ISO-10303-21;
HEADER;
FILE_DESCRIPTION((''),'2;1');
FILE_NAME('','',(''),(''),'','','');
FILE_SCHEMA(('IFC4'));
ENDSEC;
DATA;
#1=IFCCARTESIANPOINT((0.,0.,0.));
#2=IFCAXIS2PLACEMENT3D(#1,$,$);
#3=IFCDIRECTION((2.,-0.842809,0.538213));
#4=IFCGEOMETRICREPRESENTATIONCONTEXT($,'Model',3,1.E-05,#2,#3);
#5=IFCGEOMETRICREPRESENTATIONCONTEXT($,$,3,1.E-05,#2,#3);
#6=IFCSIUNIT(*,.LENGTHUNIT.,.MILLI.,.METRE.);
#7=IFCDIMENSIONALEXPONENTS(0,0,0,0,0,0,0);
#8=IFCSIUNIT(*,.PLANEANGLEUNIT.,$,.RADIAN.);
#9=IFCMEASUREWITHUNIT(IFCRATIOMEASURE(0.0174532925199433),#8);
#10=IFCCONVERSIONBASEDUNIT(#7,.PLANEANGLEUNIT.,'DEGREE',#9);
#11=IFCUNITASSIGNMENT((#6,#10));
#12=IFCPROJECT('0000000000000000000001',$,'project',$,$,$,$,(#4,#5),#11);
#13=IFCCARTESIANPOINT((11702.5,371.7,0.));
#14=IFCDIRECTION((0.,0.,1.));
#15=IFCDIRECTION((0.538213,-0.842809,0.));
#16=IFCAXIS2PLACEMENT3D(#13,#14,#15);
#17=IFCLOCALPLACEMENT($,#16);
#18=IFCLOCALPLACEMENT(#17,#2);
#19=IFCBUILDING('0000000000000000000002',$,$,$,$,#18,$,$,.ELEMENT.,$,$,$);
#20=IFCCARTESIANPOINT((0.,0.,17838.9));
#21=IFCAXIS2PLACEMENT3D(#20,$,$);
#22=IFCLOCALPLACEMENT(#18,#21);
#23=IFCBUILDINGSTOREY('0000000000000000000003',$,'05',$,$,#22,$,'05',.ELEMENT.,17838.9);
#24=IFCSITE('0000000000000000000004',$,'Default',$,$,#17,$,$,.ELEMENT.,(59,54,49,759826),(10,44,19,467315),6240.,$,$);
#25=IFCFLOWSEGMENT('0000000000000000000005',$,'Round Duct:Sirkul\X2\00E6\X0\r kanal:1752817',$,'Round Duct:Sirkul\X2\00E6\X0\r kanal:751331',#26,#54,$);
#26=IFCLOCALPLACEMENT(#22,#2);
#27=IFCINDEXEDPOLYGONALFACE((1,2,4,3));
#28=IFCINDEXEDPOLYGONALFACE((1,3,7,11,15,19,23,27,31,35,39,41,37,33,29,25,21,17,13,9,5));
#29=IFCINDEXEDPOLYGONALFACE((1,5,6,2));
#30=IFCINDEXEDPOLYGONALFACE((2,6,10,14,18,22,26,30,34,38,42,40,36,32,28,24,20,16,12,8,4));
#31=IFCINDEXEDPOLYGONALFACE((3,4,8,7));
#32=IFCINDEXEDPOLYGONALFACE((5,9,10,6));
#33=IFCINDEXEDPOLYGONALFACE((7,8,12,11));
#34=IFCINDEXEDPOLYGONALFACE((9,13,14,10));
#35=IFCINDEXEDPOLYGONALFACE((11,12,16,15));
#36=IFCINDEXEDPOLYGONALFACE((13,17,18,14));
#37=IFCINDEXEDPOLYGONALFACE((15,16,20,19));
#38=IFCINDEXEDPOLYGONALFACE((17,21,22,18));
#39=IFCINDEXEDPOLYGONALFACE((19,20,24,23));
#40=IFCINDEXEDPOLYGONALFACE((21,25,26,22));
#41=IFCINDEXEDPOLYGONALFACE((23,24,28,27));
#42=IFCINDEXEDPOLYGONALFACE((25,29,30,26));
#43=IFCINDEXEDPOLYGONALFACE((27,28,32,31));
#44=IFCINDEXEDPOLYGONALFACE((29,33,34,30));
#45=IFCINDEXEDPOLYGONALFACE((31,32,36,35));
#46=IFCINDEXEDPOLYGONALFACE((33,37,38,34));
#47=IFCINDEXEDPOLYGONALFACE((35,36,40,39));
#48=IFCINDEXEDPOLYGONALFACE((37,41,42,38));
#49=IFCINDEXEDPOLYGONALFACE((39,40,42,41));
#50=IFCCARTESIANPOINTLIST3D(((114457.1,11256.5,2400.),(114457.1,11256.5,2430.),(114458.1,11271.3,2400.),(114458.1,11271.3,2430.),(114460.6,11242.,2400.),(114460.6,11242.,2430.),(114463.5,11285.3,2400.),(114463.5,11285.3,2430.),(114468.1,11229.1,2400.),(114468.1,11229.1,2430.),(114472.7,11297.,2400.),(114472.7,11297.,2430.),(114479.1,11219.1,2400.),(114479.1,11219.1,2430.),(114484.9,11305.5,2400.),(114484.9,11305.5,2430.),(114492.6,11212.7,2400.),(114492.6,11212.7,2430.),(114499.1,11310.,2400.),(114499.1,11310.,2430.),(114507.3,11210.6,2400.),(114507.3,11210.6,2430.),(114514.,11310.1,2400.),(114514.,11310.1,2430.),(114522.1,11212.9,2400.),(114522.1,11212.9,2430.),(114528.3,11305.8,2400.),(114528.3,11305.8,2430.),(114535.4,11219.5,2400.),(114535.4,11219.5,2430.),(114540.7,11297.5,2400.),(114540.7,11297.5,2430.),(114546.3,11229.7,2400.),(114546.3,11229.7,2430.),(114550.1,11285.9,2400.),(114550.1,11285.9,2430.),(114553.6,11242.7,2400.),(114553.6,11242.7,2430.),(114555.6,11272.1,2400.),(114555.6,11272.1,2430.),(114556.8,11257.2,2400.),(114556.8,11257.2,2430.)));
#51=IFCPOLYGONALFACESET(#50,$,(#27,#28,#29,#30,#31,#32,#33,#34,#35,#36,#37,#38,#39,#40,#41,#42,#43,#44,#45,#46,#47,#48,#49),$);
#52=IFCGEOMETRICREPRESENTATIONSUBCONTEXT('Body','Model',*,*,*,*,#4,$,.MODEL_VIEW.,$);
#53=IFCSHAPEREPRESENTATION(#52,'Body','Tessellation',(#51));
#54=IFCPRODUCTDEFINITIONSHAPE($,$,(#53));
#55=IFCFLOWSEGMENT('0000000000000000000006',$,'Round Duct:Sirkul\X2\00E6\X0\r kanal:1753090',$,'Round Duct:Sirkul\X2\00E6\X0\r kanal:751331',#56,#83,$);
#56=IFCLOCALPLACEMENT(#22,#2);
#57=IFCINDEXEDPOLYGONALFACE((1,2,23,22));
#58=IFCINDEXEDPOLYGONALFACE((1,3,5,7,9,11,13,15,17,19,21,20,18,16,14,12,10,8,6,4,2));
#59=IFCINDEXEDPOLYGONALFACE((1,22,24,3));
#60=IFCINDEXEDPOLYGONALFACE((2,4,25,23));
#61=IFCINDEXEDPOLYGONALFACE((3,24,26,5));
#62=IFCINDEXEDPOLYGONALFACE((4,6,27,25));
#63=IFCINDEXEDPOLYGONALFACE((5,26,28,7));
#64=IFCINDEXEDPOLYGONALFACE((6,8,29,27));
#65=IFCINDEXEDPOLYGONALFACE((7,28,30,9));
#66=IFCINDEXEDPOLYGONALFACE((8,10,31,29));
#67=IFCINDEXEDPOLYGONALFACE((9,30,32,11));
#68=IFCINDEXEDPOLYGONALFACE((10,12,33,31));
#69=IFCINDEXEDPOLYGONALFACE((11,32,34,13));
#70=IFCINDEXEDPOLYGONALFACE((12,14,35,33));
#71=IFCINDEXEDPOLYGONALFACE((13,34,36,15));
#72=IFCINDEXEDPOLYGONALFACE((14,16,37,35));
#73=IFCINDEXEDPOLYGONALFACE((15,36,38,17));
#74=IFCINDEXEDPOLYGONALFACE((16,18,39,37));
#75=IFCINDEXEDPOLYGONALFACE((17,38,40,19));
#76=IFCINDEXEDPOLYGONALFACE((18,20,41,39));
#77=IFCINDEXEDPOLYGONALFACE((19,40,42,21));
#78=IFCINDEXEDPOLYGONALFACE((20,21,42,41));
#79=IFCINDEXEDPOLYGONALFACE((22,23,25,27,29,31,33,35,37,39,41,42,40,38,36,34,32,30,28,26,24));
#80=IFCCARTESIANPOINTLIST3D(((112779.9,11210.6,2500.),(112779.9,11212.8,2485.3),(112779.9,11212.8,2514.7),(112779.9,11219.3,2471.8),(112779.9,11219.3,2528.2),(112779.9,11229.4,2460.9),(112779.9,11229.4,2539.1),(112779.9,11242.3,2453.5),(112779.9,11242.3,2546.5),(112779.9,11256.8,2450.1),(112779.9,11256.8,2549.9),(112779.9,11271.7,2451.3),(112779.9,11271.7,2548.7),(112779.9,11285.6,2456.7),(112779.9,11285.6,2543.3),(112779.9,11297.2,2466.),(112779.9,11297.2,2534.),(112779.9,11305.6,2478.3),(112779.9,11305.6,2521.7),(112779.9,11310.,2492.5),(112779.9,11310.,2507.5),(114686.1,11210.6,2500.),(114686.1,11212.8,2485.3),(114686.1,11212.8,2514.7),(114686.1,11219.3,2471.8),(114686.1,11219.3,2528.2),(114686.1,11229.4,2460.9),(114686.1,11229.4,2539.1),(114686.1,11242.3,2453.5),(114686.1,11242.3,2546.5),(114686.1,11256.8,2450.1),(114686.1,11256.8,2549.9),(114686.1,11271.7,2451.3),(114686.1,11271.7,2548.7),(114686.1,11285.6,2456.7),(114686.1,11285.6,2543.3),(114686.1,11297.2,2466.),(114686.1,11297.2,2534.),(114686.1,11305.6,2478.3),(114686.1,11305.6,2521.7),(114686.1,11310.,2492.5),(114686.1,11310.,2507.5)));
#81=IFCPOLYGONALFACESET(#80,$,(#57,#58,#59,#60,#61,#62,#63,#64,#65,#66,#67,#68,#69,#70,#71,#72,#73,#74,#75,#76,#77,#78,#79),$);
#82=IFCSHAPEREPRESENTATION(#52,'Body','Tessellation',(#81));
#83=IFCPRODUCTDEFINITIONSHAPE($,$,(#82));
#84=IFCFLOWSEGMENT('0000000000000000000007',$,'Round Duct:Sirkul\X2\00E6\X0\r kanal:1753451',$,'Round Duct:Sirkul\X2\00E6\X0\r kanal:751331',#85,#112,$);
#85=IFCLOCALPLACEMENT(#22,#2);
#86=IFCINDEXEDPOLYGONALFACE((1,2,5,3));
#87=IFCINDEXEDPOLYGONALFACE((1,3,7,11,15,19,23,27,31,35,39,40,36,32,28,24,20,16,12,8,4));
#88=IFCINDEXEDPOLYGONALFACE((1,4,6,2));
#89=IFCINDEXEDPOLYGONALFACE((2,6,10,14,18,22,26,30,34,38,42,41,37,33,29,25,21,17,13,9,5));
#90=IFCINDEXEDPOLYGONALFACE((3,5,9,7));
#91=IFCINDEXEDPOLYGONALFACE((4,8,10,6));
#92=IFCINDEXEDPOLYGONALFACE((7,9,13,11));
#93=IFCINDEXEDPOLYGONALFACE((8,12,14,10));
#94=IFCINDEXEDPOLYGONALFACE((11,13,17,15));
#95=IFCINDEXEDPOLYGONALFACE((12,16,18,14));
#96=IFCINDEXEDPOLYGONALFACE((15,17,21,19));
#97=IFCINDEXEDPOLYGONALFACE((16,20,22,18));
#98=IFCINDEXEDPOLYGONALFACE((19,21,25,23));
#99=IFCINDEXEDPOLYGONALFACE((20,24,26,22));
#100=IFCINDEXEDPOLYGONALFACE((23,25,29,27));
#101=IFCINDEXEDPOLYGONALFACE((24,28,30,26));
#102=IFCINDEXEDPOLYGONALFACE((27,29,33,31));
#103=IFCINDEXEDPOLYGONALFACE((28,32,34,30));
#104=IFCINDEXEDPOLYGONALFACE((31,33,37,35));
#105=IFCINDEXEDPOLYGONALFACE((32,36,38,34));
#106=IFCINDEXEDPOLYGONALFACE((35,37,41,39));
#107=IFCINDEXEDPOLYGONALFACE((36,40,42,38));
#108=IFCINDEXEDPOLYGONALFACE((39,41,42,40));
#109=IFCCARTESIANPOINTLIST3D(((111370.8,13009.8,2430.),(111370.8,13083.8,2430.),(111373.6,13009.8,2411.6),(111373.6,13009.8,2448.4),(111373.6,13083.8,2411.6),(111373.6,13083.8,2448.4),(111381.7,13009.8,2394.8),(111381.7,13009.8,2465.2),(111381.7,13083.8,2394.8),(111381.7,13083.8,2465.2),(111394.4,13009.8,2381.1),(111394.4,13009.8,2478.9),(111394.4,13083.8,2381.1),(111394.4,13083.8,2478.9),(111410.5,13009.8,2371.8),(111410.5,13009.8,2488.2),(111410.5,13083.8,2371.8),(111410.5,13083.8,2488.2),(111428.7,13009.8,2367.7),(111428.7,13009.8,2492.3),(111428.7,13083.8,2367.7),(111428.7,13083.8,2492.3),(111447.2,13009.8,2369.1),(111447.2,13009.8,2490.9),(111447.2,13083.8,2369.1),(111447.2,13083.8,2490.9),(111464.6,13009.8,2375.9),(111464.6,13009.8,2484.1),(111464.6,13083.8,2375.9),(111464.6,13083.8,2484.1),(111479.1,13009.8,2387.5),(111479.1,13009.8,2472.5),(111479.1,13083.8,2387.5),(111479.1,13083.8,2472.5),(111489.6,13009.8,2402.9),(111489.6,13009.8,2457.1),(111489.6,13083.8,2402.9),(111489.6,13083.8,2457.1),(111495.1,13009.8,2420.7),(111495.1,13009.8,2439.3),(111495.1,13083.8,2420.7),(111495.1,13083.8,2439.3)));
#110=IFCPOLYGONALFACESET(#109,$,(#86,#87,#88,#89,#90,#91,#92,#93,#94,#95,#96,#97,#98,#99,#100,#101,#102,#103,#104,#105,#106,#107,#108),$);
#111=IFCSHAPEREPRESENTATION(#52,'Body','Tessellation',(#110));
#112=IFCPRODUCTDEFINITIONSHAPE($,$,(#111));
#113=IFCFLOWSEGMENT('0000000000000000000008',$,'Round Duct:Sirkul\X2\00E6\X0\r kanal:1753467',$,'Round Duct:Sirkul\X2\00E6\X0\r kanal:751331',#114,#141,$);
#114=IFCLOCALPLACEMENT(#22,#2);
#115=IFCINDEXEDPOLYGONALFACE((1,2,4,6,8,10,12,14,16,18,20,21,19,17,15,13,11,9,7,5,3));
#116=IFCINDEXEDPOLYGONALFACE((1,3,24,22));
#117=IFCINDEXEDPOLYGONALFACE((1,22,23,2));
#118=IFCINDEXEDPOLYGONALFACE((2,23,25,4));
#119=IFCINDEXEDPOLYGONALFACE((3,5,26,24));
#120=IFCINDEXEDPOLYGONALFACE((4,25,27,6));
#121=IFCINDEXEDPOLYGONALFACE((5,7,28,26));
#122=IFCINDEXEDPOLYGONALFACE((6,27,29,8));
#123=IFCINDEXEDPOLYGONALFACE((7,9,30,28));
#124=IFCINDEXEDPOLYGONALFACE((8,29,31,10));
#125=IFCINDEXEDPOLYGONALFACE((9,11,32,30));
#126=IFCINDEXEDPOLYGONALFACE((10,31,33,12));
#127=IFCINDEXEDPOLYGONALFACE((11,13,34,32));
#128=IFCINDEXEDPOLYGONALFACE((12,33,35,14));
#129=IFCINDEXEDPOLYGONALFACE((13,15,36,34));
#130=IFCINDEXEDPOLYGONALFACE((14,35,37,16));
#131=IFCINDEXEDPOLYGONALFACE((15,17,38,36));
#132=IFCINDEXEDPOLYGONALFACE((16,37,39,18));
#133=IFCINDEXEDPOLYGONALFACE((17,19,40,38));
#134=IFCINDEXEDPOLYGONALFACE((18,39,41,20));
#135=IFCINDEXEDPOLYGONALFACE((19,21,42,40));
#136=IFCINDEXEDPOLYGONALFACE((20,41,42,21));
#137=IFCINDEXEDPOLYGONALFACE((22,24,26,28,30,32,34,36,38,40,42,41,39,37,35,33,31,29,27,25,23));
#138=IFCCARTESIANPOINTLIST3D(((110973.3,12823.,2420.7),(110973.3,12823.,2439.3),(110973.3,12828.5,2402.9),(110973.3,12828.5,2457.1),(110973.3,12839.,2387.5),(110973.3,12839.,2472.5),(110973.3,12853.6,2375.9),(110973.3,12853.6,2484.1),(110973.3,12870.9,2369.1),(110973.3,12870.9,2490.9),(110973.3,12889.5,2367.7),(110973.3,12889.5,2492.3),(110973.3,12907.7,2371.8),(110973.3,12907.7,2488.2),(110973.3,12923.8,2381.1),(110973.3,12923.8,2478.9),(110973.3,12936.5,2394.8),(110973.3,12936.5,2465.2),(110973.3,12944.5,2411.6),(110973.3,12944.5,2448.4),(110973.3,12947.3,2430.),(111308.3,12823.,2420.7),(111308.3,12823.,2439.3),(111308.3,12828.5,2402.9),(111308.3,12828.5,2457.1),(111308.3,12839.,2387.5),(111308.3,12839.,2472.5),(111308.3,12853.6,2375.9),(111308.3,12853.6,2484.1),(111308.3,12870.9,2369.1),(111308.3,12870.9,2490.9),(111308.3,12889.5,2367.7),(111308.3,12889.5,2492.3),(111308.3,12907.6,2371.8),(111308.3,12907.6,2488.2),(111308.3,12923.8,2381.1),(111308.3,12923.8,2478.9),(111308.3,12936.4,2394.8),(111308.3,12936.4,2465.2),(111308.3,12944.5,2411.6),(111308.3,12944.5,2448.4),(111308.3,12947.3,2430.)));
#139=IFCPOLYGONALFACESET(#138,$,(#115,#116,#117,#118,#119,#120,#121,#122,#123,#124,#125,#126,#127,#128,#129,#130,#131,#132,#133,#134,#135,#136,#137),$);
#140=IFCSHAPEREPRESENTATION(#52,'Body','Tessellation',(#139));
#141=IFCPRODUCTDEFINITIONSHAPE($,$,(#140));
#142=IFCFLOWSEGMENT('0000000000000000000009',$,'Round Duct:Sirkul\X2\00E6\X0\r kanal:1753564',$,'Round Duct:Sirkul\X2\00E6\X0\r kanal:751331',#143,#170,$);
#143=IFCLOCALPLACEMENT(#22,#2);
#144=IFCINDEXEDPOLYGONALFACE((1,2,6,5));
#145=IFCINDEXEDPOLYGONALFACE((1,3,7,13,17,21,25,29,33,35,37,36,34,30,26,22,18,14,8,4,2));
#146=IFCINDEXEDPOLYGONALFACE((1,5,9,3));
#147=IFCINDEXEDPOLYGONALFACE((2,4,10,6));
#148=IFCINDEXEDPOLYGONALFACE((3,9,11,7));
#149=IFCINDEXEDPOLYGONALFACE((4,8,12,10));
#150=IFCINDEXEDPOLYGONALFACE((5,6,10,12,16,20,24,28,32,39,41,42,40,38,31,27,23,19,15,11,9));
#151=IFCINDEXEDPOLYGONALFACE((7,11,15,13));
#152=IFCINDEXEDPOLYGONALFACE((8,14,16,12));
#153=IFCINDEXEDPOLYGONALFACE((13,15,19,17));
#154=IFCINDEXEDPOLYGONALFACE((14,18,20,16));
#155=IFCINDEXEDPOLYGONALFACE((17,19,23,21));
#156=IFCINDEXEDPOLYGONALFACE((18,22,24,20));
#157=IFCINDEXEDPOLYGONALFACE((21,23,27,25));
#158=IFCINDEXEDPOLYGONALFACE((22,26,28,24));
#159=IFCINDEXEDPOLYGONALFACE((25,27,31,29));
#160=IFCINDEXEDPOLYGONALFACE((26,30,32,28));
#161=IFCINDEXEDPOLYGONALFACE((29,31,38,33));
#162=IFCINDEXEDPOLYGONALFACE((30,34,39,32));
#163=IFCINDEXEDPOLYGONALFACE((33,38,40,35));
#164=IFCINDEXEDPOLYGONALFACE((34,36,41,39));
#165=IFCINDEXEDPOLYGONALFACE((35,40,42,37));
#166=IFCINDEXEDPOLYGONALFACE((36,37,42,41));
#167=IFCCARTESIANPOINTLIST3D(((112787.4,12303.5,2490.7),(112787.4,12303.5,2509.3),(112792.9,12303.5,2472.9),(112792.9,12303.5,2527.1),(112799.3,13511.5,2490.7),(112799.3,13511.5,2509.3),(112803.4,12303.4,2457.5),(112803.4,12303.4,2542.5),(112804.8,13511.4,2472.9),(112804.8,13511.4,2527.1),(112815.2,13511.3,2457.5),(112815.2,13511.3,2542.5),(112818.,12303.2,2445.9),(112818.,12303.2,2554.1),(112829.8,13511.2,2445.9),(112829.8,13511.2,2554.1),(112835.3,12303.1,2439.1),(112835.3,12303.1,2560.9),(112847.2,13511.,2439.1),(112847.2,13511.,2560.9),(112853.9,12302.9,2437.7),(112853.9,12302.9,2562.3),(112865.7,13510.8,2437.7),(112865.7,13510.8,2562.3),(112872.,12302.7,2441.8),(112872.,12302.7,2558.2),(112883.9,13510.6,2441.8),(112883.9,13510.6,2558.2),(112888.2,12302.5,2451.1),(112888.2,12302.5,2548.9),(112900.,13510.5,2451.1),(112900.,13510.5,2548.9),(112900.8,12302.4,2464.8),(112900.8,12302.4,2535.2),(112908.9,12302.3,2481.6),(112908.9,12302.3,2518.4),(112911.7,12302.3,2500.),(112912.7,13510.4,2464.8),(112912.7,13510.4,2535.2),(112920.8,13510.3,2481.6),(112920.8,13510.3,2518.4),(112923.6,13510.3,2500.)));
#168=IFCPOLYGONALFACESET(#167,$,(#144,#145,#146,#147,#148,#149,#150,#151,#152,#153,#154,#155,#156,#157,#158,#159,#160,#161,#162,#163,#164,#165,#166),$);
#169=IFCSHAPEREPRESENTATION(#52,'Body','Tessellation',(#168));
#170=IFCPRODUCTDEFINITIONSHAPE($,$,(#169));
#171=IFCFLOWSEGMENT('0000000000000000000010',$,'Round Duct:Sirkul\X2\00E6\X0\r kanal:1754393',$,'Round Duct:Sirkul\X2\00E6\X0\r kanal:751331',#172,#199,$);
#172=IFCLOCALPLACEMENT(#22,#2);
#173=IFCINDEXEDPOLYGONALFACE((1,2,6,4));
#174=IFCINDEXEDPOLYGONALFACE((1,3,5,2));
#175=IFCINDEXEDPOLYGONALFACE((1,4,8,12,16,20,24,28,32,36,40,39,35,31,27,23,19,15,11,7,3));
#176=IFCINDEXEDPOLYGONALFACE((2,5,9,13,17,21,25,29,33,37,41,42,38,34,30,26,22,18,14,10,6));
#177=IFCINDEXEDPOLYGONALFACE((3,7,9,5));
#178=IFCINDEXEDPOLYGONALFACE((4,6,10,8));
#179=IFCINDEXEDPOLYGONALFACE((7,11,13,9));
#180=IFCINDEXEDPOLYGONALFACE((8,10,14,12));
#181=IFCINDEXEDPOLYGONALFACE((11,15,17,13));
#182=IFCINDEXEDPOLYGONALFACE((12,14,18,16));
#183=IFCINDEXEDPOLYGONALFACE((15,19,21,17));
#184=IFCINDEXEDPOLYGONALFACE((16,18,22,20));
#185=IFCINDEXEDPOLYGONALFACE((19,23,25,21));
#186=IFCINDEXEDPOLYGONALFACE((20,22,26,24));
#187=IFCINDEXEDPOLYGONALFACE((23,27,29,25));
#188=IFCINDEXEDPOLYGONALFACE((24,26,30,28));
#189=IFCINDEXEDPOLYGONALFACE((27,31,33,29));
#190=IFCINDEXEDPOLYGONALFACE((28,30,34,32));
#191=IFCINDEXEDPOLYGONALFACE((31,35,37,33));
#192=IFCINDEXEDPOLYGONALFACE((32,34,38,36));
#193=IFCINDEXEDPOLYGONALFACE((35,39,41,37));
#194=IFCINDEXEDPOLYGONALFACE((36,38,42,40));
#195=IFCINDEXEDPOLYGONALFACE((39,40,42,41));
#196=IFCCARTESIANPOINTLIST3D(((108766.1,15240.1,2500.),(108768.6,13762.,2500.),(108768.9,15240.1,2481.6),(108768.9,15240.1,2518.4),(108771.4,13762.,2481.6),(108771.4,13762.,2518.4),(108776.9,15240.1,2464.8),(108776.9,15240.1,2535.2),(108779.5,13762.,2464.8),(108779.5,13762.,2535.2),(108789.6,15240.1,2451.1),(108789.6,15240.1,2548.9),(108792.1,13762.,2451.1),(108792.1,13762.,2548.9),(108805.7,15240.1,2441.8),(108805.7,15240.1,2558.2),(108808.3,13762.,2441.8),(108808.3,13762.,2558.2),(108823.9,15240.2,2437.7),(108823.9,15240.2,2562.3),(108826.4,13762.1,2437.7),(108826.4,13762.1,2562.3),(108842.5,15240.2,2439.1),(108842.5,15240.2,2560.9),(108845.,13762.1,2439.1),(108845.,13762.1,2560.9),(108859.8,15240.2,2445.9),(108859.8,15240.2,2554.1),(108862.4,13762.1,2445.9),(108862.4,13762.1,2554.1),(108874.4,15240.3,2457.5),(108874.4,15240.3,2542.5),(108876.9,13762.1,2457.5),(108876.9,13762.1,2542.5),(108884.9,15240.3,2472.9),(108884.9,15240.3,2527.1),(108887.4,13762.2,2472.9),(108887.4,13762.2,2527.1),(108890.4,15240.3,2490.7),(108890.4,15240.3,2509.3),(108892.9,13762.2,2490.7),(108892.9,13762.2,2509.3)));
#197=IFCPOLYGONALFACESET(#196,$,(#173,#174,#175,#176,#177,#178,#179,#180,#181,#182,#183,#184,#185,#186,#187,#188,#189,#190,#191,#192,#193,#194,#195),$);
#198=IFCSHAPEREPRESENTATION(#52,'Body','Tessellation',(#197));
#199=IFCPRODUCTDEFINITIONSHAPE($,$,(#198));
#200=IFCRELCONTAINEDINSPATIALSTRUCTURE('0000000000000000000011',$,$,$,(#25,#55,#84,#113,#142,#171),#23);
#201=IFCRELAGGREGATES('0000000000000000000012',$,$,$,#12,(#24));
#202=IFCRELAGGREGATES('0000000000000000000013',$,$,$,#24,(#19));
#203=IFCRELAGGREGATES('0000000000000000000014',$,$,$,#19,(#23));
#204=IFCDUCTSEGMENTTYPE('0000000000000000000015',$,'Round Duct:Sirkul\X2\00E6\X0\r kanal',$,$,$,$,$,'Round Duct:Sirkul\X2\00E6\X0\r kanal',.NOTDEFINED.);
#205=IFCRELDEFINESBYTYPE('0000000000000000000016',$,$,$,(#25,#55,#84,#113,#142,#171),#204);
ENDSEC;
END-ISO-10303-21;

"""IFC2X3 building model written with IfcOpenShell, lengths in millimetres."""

from ifc_helpers import new_model, entity, si_unit, converted_unit, direction, frame, frame_2d, origin, origin_2d_with_axis, place, context, subcontext, project, spatial, circle, extrude, type_object, element, save


model = new_model("IFC2X3")

# Units and contexts
model_context = context("Model", 3, precision=1e-05, world=origin(), true_north=direction((2.0, -0.842809, 0.538213)))
context_of_model = context(None, 3, precision=1e-05, world=origin(), true_north=direction((2.0, -0.842809, 0.538213)))
body_context = subcontext(model_context, "Body", "Model", "MODEL_VIEW")
ifc_project = project(units=[si_unit("LENGTHUNIT", "METRE", prefix="MILLI"), converted_unit("PLANEANGLEUNIT", "DEGREE", entity("IfcRatioMeasure", 0.0174532925199433), si_unit("PLANEANGLEUNIT", "RADIAN"), dimensions=[0, 0, 0, 0, 0, 0, 0])], contexts=[model_context, context_of_model])

# Site, building, storey
site_placement = place(None, frame((11702.5, 371.7, 0.0), z_axis=(0.0, 0.0, 1.0), x_axis=(0.538213, -0.842809, 0.0)))
site = spatial("IfcSite", under=ifc_project, at=site_placement, Name="Default", CompositionType="ELEMENT", RefLatitude=(59, 54, 49, 759826), RefLongitude=(10, 44, 19, 467315), RefElevation=6240.0)
building_placement = place(site_placement, origin())
building = spatial("IfcBuilding", under=site, at=building_placement, CompositionType="ELEMENT")
storey_placement = place(building_placement, frame((0.0, 0.0, 17838.9)))
storey = spatial("IfcBuildingStorey", under=building, at=storey_placement, Name="05", LongName="05", CompositionType="ELEMENT", Elevation=17838.9)

# Flow segments
duct_segment_type = type_object("IfcDuctSegmentType", Name="Round Duct:Sirkulær kanal", ElementType="Round Duct:Sirkulær kanal", PredefinedType="NOTDEFINED")
flow_segment_1_placement = place(storey_placement, origin())
element("IfcFlowSegment", 1, at=flow_segment_1_placement, inside=storey, type_object=duct_segment_type, Name="Round Duct:Sirkulær kanal:1752817", ObjectType="Round Duct:Sirkulær kanal:751331", context=body_context, shape_type="SweptSolid", body=[
    extrude(circle(Radius=50.0, at=frame_2d((0.0, 0.0), x_axis=(1.0, 0.0))), frame((114507.0, 11260.6, 2400.0), z_axis=(0.0, 0.0, 1.0), x_axis=(0.007643, -0.999971, 0.0)), (0.0, 0.0, 1.0), 30.0),
])
flow_segment_2_placement = place(storey_placement, origin())
element("IfcFlowSegment", 2, at=flow_segment_2_placement, inside=storey, type_object=duct_segment_type, Name="Round Duct:Sirkulær kanal:1753090", ObjectType="Round Duct:Sirkulær kanal:751331", context=body_context, shape_type="SweptSolid", body=[
    extrude(circle(Radius=50.0, at=origin_2d_with_axis()), frame((112779.9, 11260.6, 2500.0), z_axis=(1.0, 0.0, 0.0), x_axis=(0.0, -1.0, 0.0)), (0.0, 0.0, 1.0), 1906.2),
])
flow_segment_3_placement = place(storey_placement, origin())
element("IfcFlowSegment", 3, at=flow_segment_3_placement, inside=storey, type_object=duct_segment_type, Name="Round Duct:Sirkulær kanal:1753451", ObjectType="Round Duct:Sirkulær kanal:751331", context=body_context, shape_type="SweptSolid", body=[
    extrude(circle(Radius=62.5, at=origin_2d_with_axis()), frame((111433.3, 13009.8, 2430.0), z_axis=(0.000048, 1.0, 0.0), x_axis=(-1.0, 0.000048, 0.0)), (0.0, 0.0, 1.0), 74.0),
])
flow_segment_4_placement = place(storey_placement, origin())
element("IfcFlowSegment", 4, at=flow_segment_4_placement, inside=storey, type_object=duct_segment_type, Name="Round Duct:Sirkulær kanal:1753467", ObjectType="Round Duct:Sirkulær kanal:751331", context=body_context, shape_type="SweptSolid", body=[
    extrude(circle(Radius=62.5, at=frame_2d((0.0, 0.0), x_axis=(1.0, 0.0))), frame((110973.3, 12884.8, 2430.0), z_axis=(1.0, -0.000048, 0.0), x_axis=(0.000048, 1.0, 0.0)), (0.0, 0.0, 1.0), 335.0),
])
flow_segment_5_placement = place(storey_placement, origin())
element("IfcFlowSegment", 5, at=flow_segment_5_placement, inside=storey, type_object=duct_segment_type, Name="Round Duct:Sirkulær kanal:1753564", ObjectType="Round Duct:Sirkulær kanal:751331", context=body_context, shape_type="SweptSolid", body=[
    extrude(circle(Radius=62.5, at=frame_2d((0.0, 0.0), x_axis=(1.0, 0.0))), frame((112849.2, 12302.9, 2500.0), z_axis=(0.00981, 0.999952, 0.0), x_axis=(0.999952, -0.00981, 0.0)), (0.0, 0.0, 1.0), 1208.0),
])
flow_segment_6_placement = place(storey_placement, origin())
element("IfcFlowSegment", 6, at=flow_segment_6_placement, inside=storey, type_object=duct_segment_type, Name="Round Duct:Sirkulær kanal:1754393", ObjectType="Round Duct:Sirkulær kanal:751331", context=body_context, shape_type="SweptSolid", body=[
    extrude(circle(Radius=62.5, at=origin_2d_with_axis()), frame((108831.1, 13762.1, 2500.0), z_axis=(-0.001709, 0.999999, 0.0), x_axis=(-0.999999, -0.001709, 0.0)), (0.0, 0.0, 1.0), 1478.1),
])

save(model, "model.ifc")
